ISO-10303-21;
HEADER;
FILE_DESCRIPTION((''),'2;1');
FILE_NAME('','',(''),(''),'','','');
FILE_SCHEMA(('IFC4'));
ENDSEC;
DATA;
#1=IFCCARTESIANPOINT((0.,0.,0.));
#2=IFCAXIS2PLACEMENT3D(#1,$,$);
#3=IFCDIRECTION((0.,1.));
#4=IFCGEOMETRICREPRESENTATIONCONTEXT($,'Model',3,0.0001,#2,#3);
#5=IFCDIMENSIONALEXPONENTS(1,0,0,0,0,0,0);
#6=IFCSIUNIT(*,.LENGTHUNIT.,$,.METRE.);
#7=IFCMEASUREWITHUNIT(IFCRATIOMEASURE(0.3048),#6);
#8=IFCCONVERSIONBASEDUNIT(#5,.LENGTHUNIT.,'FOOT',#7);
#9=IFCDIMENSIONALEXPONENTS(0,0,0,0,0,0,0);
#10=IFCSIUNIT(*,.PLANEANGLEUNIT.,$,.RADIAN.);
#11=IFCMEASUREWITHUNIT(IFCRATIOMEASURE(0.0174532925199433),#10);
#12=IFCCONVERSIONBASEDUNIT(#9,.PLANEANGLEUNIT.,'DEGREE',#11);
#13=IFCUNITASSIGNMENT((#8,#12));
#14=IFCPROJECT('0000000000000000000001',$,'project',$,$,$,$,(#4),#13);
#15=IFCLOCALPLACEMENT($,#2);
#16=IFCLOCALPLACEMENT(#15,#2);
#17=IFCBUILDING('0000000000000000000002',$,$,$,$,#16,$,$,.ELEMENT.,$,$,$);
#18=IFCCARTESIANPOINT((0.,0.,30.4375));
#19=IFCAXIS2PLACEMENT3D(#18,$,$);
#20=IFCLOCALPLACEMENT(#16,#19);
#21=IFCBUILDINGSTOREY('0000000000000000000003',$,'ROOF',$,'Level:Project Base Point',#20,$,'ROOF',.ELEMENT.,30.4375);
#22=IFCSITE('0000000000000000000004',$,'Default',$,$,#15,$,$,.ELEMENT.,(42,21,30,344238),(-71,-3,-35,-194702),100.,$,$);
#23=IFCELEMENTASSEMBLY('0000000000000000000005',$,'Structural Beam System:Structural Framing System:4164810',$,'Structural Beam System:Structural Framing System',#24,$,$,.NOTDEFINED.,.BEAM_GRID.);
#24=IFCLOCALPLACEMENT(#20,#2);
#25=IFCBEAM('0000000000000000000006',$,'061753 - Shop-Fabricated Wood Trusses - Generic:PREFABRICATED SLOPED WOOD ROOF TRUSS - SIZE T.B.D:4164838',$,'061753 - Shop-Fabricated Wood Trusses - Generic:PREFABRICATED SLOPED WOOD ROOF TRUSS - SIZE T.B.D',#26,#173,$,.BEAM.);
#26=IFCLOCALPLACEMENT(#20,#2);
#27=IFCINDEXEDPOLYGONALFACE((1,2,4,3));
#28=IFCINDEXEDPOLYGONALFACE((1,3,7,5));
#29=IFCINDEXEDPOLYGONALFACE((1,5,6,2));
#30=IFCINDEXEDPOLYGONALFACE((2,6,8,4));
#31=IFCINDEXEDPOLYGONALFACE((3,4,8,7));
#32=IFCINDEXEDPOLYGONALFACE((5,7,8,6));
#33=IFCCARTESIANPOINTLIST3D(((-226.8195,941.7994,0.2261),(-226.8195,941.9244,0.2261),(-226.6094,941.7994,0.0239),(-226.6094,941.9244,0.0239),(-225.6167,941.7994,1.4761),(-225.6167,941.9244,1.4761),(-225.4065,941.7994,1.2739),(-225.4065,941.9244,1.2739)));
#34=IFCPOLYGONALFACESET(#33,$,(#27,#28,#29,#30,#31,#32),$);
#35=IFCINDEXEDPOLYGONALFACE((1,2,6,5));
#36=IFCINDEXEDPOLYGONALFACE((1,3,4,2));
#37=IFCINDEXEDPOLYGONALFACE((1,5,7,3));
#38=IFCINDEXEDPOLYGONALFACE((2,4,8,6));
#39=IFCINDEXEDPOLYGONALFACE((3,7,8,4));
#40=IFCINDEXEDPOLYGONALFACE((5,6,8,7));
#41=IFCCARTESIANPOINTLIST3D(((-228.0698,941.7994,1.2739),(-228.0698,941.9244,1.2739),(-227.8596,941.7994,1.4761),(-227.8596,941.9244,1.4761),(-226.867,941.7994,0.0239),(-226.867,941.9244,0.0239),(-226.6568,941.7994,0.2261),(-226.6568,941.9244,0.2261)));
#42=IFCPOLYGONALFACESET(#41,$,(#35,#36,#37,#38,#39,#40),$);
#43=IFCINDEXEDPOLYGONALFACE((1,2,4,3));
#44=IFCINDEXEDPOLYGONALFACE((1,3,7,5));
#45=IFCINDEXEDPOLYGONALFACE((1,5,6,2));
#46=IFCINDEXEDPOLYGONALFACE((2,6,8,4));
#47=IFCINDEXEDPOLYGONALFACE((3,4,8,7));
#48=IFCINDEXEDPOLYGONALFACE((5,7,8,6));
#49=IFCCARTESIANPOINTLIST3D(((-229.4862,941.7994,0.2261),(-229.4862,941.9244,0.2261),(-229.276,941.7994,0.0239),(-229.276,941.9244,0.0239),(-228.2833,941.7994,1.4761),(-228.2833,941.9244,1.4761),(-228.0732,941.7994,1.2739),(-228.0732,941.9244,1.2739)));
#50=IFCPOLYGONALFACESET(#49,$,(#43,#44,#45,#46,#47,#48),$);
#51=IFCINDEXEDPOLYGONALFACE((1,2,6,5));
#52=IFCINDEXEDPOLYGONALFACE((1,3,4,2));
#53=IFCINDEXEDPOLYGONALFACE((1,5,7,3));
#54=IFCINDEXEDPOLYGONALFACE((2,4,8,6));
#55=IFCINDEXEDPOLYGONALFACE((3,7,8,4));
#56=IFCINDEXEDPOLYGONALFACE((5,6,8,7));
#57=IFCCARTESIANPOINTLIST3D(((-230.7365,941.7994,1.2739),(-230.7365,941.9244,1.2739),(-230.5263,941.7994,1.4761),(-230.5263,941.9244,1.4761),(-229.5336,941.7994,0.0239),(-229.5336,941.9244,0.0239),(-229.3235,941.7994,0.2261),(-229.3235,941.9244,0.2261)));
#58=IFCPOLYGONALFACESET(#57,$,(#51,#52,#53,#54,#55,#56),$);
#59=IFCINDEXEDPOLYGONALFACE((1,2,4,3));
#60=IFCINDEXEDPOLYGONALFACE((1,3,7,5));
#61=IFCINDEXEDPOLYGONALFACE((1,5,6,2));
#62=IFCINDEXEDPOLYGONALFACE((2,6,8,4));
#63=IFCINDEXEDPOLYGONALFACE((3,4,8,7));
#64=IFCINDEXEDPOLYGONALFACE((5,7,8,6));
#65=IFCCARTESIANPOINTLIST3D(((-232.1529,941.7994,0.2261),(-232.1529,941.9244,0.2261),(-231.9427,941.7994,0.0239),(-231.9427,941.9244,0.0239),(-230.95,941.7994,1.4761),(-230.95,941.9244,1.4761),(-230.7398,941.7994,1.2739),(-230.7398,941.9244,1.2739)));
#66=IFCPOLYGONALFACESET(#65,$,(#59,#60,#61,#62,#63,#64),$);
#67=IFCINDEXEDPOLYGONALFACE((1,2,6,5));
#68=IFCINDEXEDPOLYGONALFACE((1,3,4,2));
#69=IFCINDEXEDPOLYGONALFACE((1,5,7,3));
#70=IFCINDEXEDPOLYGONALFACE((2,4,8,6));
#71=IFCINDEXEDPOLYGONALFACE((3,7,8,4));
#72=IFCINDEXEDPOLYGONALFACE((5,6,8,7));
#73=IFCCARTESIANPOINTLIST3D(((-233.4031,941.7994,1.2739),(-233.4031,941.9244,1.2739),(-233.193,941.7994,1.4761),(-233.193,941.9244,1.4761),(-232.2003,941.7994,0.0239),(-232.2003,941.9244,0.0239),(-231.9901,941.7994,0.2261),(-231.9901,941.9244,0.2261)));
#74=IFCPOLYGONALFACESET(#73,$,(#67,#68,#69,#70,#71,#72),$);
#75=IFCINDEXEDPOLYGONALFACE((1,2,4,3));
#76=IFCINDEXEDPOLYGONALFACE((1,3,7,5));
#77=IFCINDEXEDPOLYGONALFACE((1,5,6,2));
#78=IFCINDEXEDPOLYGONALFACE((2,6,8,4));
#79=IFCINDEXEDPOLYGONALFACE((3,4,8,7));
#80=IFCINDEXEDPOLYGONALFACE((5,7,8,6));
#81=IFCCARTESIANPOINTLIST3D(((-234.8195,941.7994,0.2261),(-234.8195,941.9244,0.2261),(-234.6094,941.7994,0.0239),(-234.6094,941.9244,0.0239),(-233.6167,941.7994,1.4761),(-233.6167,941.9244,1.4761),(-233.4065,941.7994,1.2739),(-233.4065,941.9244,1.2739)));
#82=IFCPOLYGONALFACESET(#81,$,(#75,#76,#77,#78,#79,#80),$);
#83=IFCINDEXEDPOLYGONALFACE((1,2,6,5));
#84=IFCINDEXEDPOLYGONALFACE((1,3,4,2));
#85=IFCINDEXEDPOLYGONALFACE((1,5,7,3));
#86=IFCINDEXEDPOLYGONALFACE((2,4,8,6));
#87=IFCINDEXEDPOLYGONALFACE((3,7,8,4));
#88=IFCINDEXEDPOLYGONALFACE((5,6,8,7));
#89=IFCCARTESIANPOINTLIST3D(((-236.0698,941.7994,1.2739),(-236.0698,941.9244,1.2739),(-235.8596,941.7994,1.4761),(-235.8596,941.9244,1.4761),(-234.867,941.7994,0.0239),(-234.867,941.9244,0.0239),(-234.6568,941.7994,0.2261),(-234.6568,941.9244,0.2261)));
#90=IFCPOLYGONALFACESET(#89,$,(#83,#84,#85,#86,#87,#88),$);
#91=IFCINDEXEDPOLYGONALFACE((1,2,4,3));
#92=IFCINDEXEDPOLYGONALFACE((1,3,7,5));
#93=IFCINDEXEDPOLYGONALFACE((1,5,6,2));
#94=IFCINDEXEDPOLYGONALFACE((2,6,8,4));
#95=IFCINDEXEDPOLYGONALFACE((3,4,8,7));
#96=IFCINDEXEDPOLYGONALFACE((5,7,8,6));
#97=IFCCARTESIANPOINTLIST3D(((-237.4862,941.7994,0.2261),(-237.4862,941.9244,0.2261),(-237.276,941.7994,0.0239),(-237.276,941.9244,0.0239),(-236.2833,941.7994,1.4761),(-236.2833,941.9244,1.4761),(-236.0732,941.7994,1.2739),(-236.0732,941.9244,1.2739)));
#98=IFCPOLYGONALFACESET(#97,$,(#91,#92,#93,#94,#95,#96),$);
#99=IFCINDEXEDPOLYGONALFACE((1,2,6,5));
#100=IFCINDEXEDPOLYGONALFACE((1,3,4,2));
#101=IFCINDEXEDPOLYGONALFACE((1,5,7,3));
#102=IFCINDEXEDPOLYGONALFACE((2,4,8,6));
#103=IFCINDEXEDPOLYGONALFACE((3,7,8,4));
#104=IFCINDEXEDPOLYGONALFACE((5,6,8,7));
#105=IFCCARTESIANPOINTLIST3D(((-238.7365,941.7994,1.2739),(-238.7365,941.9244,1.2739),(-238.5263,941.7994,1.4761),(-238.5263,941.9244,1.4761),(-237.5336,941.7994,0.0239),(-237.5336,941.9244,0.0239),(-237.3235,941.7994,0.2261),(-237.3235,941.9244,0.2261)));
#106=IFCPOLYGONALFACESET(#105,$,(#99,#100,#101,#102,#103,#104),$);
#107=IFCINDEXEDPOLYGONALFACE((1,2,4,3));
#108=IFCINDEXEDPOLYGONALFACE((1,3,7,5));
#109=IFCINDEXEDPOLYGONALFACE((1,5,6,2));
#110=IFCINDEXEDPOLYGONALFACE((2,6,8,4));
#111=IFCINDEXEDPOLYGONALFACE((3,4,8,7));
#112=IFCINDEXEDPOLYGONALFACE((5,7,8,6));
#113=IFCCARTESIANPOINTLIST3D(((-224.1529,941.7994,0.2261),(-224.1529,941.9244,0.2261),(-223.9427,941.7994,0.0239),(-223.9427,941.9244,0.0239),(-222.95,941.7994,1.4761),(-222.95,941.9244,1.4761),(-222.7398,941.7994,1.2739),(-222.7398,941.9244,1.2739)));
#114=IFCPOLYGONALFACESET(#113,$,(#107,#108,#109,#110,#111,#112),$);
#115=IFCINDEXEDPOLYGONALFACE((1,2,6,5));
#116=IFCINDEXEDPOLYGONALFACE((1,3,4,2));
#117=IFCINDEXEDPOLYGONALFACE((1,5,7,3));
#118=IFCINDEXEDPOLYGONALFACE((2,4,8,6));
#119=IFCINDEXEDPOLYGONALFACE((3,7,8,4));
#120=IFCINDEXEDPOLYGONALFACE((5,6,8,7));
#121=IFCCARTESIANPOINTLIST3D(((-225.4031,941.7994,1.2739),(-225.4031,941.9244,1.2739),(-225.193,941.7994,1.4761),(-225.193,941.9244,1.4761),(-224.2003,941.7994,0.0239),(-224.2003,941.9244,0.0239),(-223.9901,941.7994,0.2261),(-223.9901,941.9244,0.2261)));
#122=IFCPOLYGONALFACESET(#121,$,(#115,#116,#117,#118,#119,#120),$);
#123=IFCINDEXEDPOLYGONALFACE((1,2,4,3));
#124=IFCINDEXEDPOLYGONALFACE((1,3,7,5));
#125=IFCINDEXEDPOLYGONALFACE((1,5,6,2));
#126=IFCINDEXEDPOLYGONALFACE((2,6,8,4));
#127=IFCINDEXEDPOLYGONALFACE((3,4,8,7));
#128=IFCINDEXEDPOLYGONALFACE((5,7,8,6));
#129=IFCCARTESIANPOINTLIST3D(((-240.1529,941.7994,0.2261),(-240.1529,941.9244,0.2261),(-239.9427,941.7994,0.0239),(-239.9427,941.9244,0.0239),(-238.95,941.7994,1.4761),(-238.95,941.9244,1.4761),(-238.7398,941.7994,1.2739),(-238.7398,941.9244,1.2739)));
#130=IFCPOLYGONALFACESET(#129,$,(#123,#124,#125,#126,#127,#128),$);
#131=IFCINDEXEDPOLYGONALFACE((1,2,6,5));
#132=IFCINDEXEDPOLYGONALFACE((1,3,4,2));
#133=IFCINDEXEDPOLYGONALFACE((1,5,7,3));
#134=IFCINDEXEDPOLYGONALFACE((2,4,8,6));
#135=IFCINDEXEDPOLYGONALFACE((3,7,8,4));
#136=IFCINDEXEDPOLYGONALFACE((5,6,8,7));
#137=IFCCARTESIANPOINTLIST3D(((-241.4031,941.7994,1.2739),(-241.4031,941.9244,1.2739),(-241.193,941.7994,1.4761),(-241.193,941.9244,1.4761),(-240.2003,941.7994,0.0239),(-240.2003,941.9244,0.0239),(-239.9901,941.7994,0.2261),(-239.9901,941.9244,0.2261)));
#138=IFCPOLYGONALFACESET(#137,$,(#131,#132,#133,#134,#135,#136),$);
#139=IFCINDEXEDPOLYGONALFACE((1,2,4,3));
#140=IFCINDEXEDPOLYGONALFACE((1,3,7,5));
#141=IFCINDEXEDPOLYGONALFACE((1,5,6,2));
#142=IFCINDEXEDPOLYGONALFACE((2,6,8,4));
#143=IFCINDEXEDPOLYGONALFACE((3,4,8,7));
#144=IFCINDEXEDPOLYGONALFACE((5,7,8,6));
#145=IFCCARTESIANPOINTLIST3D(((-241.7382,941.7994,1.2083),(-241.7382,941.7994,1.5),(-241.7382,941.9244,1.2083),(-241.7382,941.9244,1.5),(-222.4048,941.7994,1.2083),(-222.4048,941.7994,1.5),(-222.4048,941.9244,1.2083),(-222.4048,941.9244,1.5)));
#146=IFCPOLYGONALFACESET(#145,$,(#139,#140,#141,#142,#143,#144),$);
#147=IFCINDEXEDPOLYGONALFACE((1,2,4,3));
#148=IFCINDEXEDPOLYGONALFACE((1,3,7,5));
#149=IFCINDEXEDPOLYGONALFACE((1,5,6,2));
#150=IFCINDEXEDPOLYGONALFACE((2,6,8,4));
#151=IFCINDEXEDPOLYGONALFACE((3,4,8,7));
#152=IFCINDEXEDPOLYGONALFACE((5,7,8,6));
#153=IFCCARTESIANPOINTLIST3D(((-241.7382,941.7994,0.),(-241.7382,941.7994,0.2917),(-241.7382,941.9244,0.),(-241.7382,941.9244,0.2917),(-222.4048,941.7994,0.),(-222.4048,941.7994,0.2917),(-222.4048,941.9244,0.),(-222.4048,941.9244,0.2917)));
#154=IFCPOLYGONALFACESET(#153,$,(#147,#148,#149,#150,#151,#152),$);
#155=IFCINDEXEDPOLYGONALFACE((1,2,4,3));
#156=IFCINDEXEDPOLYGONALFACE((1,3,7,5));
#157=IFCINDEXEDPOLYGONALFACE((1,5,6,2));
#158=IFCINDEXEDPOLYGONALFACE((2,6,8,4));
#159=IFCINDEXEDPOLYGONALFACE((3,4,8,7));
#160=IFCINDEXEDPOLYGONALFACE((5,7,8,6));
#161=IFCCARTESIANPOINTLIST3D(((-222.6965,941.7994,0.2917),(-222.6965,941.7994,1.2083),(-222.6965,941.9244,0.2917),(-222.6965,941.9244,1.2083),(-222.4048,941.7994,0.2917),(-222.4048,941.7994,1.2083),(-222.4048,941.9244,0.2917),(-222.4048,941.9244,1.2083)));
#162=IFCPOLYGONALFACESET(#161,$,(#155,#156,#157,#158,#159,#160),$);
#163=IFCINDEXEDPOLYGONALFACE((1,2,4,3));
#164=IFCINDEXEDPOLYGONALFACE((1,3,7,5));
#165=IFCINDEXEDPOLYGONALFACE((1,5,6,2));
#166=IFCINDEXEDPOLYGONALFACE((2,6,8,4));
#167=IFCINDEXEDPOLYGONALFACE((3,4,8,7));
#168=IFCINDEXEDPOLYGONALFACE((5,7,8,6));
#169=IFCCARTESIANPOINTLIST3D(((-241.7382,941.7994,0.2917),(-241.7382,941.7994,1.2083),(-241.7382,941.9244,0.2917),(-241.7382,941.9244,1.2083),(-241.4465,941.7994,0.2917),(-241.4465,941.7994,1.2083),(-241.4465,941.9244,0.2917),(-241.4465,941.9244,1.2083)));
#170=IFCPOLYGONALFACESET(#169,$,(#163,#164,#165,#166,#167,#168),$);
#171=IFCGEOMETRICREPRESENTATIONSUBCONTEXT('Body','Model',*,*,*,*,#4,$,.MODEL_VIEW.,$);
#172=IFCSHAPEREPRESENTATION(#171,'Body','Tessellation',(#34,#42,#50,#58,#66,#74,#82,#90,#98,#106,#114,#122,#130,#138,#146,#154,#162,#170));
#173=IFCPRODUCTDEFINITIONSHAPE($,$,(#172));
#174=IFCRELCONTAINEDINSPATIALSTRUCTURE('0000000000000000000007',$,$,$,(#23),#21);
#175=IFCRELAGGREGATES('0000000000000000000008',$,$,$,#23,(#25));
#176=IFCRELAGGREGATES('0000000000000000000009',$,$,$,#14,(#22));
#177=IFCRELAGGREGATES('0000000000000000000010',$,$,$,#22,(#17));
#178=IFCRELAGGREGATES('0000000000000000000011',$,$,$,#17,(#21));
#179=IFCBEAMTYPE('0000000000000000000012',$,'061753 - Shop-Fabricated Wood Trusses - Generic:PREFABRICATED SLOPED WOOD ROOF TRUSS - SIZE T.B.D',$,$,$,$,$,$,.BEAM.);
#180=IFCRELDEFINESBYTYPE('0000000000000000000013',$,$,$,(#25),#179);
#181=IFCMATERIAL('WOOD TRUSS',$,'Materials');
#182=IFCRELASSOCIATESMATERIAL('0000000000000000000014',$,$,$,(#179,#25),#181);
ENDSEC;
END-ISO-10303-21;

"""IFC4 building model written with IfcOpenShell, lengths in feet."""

from ifc_helpers import new_model, entity, si_unit, converted_unit, direction, frame, frame_2d, origin, origin_2d_with_axis, place, context, subcontext, project, spatial, rectangle, extrude, source, transform, mapped, material, material_profile, profile_set, profile_usage, type_object, type_shapes, element, aggregate, save


model = new_model("IFC4")

# Units and contexts
model_context = context("Model", 3, precision=0.0001, world=origin(), true_north=direction((0.0, 1.0)))
body_context = subcontext(model_context, "Body", "Model", "MODEL_VIEW")
ifc_project = project(units=[converted_unit("LENGTHUNIT", "FOOT", entity("IfcRatioMeasure", 0.3048), si_unit("LENGTHUNIT", "METRE"), dimensions=[1, 0, 0, 0, 0, 0, 0]), converted_unit("PLANEANGLEUNIT", "DEGREE", entity("IfcRatioMeasure", 0.0174532925199433), si_unit("PLANEANGLEUNIT", "RADIAN"), dimensions=[0, 0, 0, 0, 0, 0, 0])], contexts=[model_context])

# Site, building, storey
site_placement = place(None, origin())
site = spatial("IfcSite", under=ifc_project, at=site_placement, Name="Default", CompositionType="ELEMENT", RefLatitude=(42, 21, 30, 344238), RefLongitude=(-71, -3, -35, -194702), RefElevation=100.0)
building_placement = place(site_placement, origin())
building = spatial("IfcBuilding", under=site, at=building_placement, CompositionType="ELEMENT")
storey_placement = place(building_placement, frame((0.0, 0.0, 30.4375)))
storey = spatial("IfcBuildingStorey", under=building, at=storey_placement, Name="ROOF", ObjectType="Level:Project Base Point", LongName="ROOF", CompositionType="ELEMENT", Elevation=30.4375)

# Element assembly, beam
assembly_1_placement = place(storey_placement, origin())
assembly_1 = element("IfcElementAssembly", 1, at=assembly_1_placement, inside=storey, Name="Structural Beam System:Structural Framing System:4164810", ObjectType="Structural Beam System:Structural Framing System", AssemblyPlace="NOTDEFINED", PredefinedType="BEAM_GRID")
ifc_material_1 = material(Name="WOOD TRUSS", Category="Materials")
ifc_material_profile_1 = material_profile(ifc_material_1, rectangle(XDim=1.7347, YDim=0.125, at=origin_2d_with_axis()), Name="PREFABRICATED SLOPED WOOD ROOF TRUSS - SIZE T.B.D")
ifc_material_profile_2 = material_profile(ifc_material_1, rectangle(XDim=1.7347, YDim=0.125, at=frame_2d((0.0, 0.0), x_axis=(1.0, 0.0))), Name="PREFABRICATED SLOPED WOOD ROOF TRUSS - SIZE T.B.D")
ifc_material_profile_3 = material_profile(ifc_material_1, rectangle(XDim=1.7347, YDim=0.125, at=origin_2d_with_axis()), Name="PREFABRICATED SLOPED WOOD ROOF TRUSS - SIZE T.B.D")
ifc_material_profile_4 = material_profile(ifc_material_1, rectangle(XDim=1.7347, YDim=0.125, at=origin_2d_with_axis()), Name="PREFABRICATED SLOPED WOOD ROOF TRUSS - SIZE T.B.D")
ifc_material_profile_5 = material_profile(ifc_material_1, rectangle(XDim=1.7347, YDim=0.125, at=frame_2d((0.0, 0.0), x_axis=(1.0, 0.0))), Name="PREFABRICATED SLOPED WOOD ROOF TRUSS - SIZE T.B.D")
ifc_material_profile_6 = material_profile(ifc_material_1, rectangle(XDim=1.7347, YDim=0.125, at=frame_2d((0.0, 0.0), x_axis=(1.0, 0.0))), Name="PREFABRICATED SLOPED WOOD ROOF TRUSS - SIZE T.B.D")
ifc_material_profile_7 = material_profile(ifc_material_1, rectangle(XDim=1.7347, YDim=0.125, at=frame_2d((0.0, 0.0), x_axis=(1.0, 0.0))), Name="PREFABRICATED SLOPED WOOD ROOF TRUSS - SIZE T.B.D")
ifc_material_profile_8 = material_profile(ifc_material_1, rectangle(XDim=1.7347, YDim=0.125, at=frame_2d((0.0, 0.0), x_axis=(1.0, 0.0))), Name="PREFABRICATED SLOPED WOOD ROOF TRUSS - SIZE T.B.D")
ifc_material_profile_9 = material_profile(ifc_material_1, rectangle(XDim=1.7347, YDim=0.125, at=origin_2d_with_axis()), Name="PREFABRICATED SLOPED WOOD ROOF TRUSS - SIZE T.B.D")
ifc_material_profile_10 = material_profile(ifc_material_1, rectangle(XDim=1.7347, YDim=0.125, at=frame_2d((0.0, 0.0), x_axis=(1.0, 0.0))), Name="PREFABRICATED SLOPED WOOD ROOF TRUSS - SIZE T.B.D")
ifc_material_profile_11 = material_profile(ifc_material_1, rectangle(XDim=0.2917, YDim=0.125, at=frame_2d((0.0, 0.0), x_axis=(1.0, 0.0))), Name="PREFABRICATED SLOPED WOOD ROOF TRUSS - SIZE T.B.D")
ifc_material_profile_12 = material_profile(ifc_material_1, rectangle(XDim=0.2917, YDim=0.125, at=frame_2d((0.0, 0.0), x_axis=(1.0, 0.0))), Name="PREFABRICATED SLOPED WOOD ROOF TRUSS - SIZE T.B.D")
ifc_material_profile_13 = material_profile(ifc_material_1, rectangle(XDim=0.9167, YDim=0.125, at=frame_2d((0.0, 0.0), x_axis=(1.0, 0.0))), Name="PREFABRICATED SLOPED WOOD ROOF TRUSS - SIZE T.B.D")
ifc_material_profile_14 = material_profile(ifc_material_1, rectangle(XDim=0.9167, YDim=0.125, at=frame_2d((0.0, 0.0), x_axis=(1.0, 0.0))), Name="PREFABRICATED SLOPED WOOD ROOF TRUSS - SIZE T.B.D")
ifc_profile_set_1 = profile_set([ifc_material_profile_1, ifc_material_profile_2, ifc_material_profile_3, ifc_material_profile_4, ifc_material_profile_5, ifc_material_profile_6, ifc_material_profile_7, ifc_material_profile_8, ifc_material_profile_9, ifc_material_profile_10, ifc_material_profile_11, ifc_material_profile_12, ifc_material_profile_13, ifc_material_profile_14], Name="PREFABRICATED SLOPED WOOD ROOF TRUSS - SIZE T.B.D")
beam_type_1 = type_object("IfcBeamType", Name="061753 - Shop-Fabricated Wood Trusses - Generic:PREFABRICATED SLOPED WOOD ROOF TRUSS - SIZE T.B.D", PredefinedType="BEAM", material=ifc_profile_set_1)
shared_shape_1 = source(origin(), body_context, "Body", "SweptSolid", [
    extrude(rectangle(XDim=1.7347, YDim=0.125, at=frame_2d((0.0, 0.0), x_axis=(1.0, 0.0))), frame((5.8534, 0.0, 0.1011), z_axis=(0.720569, 0.0, -0.693383), x_axis=(0.693383, 0.0, 0.720569)), (0.0, 0.0, 1.0), 0.2917),
    extrude(rectangle(XDim=1.7347, YDim=0.125, at=frame_2d((0.0, 0.0), x_axis=(1.0, 0.0))), frame((4.6031, 0.0, -0.1011), z_axis=(0.720569, 0.0, 0.693383), x_axis=(0.693383, 0.0, -0.720569)), (0.0, 0.0, 1.0), 0.2917),
    extrude(rectangle(XDim=1.7347, YDim=0.125, at=frame_2d((0.0, 0.0), x_axis=(1.0, 0.0))), frame((3.1867, 0.0, 0.1011), z_axis=(0.720569, 0.0, -0.693383), x_axis=(0.693383, 0.0, 0.720569)), (0.0, 0.0, 1.0), 0.2917),
    extrude(rectangle(XDim=1.7347, YDim=0.125, at=frame_2d((0.0, 0.0), x_axis=(1.0, 0.0))), frame((1.9364, 0.0, -0.1011), z_axis=(0.720569, 0.0, 0.693383), x_axis=(0.693383, 0.0, -0.720569)), (0.0, 0.0, 1.0), 0.2917),
    extrude(rectangle(XDim=1.7347, YDim=0.125, at=frame_2d((0.0, 0.0), x_axis=(1.0, 0.0))), frame((0.5201, 0.0, 0.1011), z_axis=(0.720569, 0.0, -0.693383), x_axis=(0.693383, 0.0, 0.720569)), (0.0, 0.0, 1.0), 0.2917),
    extrude(rectangle(XDim=1.7347, YDim=0.125, at=origin_2d_with_axis()), frame((-0.7302, 0.0, -0.1011), z_axis=(0.720569, 0.0, 0.693383), x_axis=(0.693383, 0.0, -0.720569)), (0.0, 0.0, 1.0), 0.2917),
    extrude(rectangle(XDim=1.7347, YDim=0.125, at=frame_2d((0.0, 0.0), x_axis=(1.0, 0.0))), frame((-2.1466, 0.0, 0.1011), z_axis=(0.720569, 0.0, -0.693383), x_axis=(0.693383, 0.0, 0.720569)), (0.0, 0.0, 1.0), 0.2917),
    extrude(rectangle(XDim=1.7347, YDim=0.125, at=frame_2d((0.0, 0.0), x_axis=(1.0, 0.0))), frame((-3.3969, 0.0, -0.1011), z_axis=(0.720569, 0.0, 0.693383), x_axis=(0.693383, 0.0, -0.720569)), (0.0, 0.0, 1.0), 0.2917),
    extrude(rectangle(XDim=1.7347, YDim=0.125, at=origin_2d_with_axis()), frame((-4.8133, 0.0, 0.1011), z_axis=(0.720569, 0.0, -0.693383), x_axis=(0.693383, 0.0, 0.720569)), (0.0, 0.0, 1.0), 0.2917),
    extrude(rectangle(XDim=1.7347, YDim=0.125, at=frame_2d((0.0, 0.0), x_axis=(1.0, 0.0))), frame((-6.0636, 0.0, -0.1011), z_axis=(0.720569, 0.0, 0.693383), x_axis=(0.693383, 0.0, -0.720569)), (0.0, 0.0, 1.0), 0.2917),
    extrude(rectangle(XDim=1.7347, YDim=0.125, at=frame_2d((0.0, 0.0), x_axis=(1.0, 0.0))), frame((8.5201, 0.0, 0.1011), z_axis=(0.720569, 0.0, -0.693383), x_axis=(0.693383, 0.0, 0.720569)), (0.0, 0.0, 1.0), 0.2917),
    extrude(rectangle(XDim=1.7347, YDim=0.125, at=origin_2d_with_axis()), frame((7.2698, 0.0, -0.1011), z_axis=(0.720569, 0.0, 0.693383), x_axis=(0.693383, 0.0, -0.720569)), (0.0, 0.0, 1.0), 0.2917),
    extrude(rectangle(XDim=1.7347, YDim=0.125, at=frame_2d((0.0, 0.0), x_axis=(1.0, 0.0))), frame((-7.4799, 0.0, 0.1011), z_axis=(0.720569, 0.0, -0.693383), x_axis=(0.693383, 0.0, 0.720569)), (0.0, 0.0, 1.0), 0.2917),
    extrude(rectangle(XDim=1.7347, YDim=0.125, at=origin_2d_with_axis()), frame((-8.7302, 0.0, -0.1011), z_axis=(0.720569, 0.0, 0.693383), x_axis=(0.693383, 0.0, -0.720569)), (0.0, 0.0, 1.0), 0.2917),
    extrude(rectangle(XDim=0.2917, YDim=0.125, at=frame_2d((0.0, 0.0), x_axis=(1.0, 0.0))), frame((-9.6667, 0.0, 0.6042), z_axis=(1.0, 0.0, 0.0), x_axis=(0.0, 0.0, -1.0)), (0.0, 0.0, 1.0), 19.3333),
    extrude(rectangle(XDim=0.2917, YDim=0.125, at=frame_2d((0.0, 0.0), x_axis=(1.0, 0.0))), frame((-9.6667, 0.0, -0.6042), z_axis=(1.0, 0.0, 0.0), x_axis=(0.0, 0.0, -1.0)), (0.0, 0.0, 1.0), 19.3333),
    extrude(rectangle(XDim=0.9167, YDim=0.125, at=frame_2d((0.0, 0.0), x_axis=(1.0, 0.0))), frame((9.375, 0.0, 0.0), z_axis=(1.0, 0.0, 0.0), x_axis=(0.0, 0.0, -1.0)), (0.0, 0.0, 1.0), 0.2917),
    extrude(rectangle(XDim=0.9167, YDim=0.125, at=frame_2d((0.0, 0.0), x_axis=(1.0, 0.0))), frame((-9.6667, 0.0, 0.0), z_axis=(1.0, 0.0, 0.0), x_axis=(0.0, 0.0, -1.0)), (0.0, 0.0, 1.0), 0.2917),
])
type_shapes(beam_type_1, [shared_shape_1])
ifc_profile_usage_1 = profile_usage(ifc_profile_set_1, cardinal=8)
beam_1_placement = place(assembly_1_placement, frame((-232.0715, 941.8619, 0.75)))
beam_1 = element("IfcBeam", 2, at=beam_1_placement, type_object=beam_type_1, material=ifc_profile_usage_1, Name="061753 - Shop-Fabricated Wood Trusses - Generic:PREFABRICATED SLOPED WOOD ROOF TRUSS - SIZE T.B.D:4164838", ObjectType="061753 - Shop-Fabricated Wood Trusses - Generic:PREFABRICATED SLOPED WOOD ROOF TRUSS - SIZE T.B.D", PredefinedType="BEAM", context=body_context, shape_type="MappedRepresentation", body=[
    mapped(shared_shape_1, transform((0.0, 0.0, 0.0), scale=1.0)),
])
aggregate(assembly_1, [beam_1])

save(model, "model.ifc")
